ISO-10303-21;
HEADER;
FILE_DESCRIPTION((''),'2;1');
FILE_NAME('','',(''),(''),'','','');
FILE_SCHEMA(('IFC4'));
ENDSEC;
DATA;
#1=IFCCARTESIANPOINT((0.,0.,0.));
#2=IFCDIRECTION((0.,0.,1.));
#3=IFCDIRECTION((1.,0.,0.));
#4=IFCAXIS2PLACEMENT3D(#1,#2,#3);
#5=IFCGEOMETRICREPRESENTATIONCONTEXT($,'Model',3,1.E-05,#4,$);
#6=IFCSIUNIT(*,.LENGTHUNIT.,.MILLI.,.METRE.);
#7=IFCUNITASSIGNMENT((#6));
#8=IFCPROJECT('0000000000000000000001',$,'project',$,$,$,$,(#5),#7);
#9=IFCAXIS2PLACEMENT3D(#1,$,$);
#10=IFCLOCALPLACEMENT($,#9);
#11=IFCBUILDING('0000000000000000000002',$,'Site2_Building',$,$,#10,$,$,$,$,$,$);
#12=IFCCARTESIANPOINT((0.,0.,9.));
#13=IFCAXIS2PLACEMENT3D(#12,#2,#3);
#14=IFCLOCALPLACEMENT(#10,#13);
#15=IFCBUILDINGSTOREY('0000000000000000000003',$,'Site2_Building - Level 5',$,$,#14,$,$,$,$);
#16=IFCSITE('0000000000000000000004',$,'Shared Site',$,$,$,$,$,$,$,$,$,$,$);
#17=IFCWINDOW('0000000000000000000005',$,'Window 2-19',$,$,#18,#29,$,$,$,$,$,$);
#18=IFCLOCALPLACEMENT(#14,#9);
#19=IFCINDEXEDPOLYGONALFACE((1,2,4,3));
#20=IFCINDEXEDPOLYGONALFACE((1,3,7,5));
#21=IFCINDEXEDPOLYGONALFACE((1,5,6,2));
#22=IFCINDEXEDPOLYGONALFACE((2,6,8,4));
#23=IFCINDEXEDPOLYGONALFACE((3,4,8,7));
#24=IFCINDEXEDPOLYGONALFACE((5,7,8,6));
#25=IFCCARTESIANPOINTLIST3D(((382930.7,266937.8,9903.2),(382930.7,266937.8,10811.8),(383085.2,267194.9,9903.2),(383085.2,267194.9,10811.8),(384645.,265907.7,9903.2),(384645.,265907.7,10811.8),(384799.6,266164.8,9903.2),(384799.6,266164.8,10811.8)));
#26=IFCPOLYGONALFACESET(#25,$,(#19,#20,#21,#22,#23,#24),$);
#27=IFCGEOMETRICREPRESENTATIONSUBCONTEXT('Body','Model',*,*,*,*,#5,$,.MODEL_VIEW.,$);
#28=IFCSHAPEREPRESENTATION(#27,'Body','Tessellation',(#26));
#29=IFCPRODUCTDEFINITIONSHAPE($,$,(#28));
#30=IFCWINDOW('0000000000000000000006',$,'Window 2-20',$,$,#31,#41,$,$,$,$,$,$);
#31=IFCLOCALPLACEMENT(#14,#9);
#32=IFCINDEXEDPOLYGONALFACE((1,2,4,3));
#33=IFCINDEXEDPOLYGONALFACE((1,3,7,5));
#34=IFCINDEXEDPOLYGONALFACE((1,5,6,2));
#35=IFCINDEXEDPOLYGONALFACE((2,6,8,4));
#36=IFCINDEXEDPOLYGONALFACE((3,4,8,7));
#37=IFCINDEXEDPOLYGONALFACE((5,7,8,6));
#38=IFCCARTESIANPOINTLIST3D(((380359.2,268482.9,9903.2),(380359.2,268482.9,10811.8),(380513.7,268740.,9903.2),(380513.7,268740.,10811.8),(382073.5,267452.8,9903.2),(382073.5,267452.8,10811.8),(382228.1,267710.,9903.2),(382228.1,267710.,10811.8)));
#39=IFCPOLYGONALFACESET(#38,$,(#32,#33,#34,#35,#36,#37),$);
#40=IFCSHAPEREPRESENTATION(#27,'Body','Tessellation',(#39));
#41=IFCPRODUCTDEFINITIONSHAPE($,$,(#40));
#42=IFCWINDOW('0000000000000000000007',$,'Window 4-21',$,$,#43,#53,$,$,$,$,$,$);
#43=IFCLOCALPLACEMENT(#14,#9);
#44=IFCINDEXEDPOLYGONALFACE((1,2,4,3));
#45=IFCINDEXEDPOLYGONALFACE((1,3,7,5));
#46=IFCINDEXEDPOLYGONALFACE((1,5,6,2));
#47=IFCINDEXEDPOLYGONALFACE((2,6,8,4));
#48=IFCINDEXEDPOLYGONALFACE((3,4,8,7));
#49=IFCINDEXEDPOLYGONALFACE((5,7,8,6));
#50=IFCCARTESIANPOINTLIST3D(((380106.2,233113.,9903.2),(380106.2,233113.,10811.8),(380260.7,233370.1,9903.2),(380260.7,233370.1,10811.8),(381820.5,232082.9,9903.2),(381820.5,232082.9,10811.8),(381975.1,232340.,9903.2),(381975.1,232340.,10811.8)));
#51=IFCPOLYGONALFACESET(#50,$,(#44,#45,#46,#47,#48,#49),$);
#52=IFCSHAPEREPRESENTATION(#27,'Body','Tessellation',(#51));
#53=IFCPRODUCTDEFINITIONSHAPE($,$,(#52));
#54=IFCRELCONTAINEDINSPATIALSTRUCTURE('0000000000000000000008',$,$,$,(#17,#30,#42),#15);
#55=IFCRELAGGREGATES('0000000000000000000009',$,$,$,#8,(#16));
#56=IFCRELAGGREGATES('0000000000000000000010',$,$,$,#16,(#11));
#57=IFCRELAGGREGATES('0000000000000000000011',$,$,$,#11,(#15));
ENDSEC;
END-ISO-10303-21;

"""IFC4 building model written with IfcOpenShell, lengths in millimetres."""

from ifc_helpers import new_model, si_unit, frame, origin, origin_with_axes, place, context, subcontext, project, spatial, indexed_curve, outline, extrude, element, save


model = new_model("IFC4")

# Units and contexts
model_context = context("Model", 3, precision=1e-05, world=origin_with_axes())
body_context = subcontext(model_context, "Body", "Model", "MODEL_VIEW")
ifc_project = project(units=[si_unit("LENGTHUNIT", "METRE", prefix="MILLI")], contexts=[model_context])

# Site, building, storey
site = spatial("IfcSite", under=ifc_project, Name="Shared Site")
building_placement = place(None, origin())
building = spatial("IfcBuilding", under=site, at=building_placement, Name="Site2_Building")
storey_placement = place(building_placement, frame((0.0, 0.0, 9.0), z_axis=(0.0, 0.0, 1.0), x_axis=(1.0, 0.0, 0.0)))
storey = spatial("IfcBuildingStorey", under=building, at=storey_placement, Name="Site2_Building - Level 5")

# Windows
for number, where, z_axis, x_axis, name in (
    (1, (384799.6, 266164.8, 9903.2), (0.0, 0.0, 1.0), (-0.857167, 0.515038, 0.0), "Window 2-19"),
    (2, (382228.1, 267710.0, 9903.2), (0.0, 0.0, 1.0), (-0.857167, 0.515038, 0.0), "Window 2-20"),
    (3, (380106.2, 233113.0, 9903.2), (0.0, 0.0, 1.0), (0.857167, -0.515038, 0.0), "Window 4-21"),
):
    element("IfcWindow", number, at=place(storey_placement, frame(where, z_axis=z_axis, x_axis=x_axis)), inside=storey, Name=name, context=body_context, shape_type="SweptSolid", body=[
        extrude(outline(indexed_curve([(0.0, 0.0), (0.0, 300.0), (2000.0, 300.0), (2000.0, 0.0), (0.0, 0.0)], self_intersect=False)), origin_with_axes(), (0.0, 0.0, 1.0), 908.6),
    ])

save(model, "model.ifc")
